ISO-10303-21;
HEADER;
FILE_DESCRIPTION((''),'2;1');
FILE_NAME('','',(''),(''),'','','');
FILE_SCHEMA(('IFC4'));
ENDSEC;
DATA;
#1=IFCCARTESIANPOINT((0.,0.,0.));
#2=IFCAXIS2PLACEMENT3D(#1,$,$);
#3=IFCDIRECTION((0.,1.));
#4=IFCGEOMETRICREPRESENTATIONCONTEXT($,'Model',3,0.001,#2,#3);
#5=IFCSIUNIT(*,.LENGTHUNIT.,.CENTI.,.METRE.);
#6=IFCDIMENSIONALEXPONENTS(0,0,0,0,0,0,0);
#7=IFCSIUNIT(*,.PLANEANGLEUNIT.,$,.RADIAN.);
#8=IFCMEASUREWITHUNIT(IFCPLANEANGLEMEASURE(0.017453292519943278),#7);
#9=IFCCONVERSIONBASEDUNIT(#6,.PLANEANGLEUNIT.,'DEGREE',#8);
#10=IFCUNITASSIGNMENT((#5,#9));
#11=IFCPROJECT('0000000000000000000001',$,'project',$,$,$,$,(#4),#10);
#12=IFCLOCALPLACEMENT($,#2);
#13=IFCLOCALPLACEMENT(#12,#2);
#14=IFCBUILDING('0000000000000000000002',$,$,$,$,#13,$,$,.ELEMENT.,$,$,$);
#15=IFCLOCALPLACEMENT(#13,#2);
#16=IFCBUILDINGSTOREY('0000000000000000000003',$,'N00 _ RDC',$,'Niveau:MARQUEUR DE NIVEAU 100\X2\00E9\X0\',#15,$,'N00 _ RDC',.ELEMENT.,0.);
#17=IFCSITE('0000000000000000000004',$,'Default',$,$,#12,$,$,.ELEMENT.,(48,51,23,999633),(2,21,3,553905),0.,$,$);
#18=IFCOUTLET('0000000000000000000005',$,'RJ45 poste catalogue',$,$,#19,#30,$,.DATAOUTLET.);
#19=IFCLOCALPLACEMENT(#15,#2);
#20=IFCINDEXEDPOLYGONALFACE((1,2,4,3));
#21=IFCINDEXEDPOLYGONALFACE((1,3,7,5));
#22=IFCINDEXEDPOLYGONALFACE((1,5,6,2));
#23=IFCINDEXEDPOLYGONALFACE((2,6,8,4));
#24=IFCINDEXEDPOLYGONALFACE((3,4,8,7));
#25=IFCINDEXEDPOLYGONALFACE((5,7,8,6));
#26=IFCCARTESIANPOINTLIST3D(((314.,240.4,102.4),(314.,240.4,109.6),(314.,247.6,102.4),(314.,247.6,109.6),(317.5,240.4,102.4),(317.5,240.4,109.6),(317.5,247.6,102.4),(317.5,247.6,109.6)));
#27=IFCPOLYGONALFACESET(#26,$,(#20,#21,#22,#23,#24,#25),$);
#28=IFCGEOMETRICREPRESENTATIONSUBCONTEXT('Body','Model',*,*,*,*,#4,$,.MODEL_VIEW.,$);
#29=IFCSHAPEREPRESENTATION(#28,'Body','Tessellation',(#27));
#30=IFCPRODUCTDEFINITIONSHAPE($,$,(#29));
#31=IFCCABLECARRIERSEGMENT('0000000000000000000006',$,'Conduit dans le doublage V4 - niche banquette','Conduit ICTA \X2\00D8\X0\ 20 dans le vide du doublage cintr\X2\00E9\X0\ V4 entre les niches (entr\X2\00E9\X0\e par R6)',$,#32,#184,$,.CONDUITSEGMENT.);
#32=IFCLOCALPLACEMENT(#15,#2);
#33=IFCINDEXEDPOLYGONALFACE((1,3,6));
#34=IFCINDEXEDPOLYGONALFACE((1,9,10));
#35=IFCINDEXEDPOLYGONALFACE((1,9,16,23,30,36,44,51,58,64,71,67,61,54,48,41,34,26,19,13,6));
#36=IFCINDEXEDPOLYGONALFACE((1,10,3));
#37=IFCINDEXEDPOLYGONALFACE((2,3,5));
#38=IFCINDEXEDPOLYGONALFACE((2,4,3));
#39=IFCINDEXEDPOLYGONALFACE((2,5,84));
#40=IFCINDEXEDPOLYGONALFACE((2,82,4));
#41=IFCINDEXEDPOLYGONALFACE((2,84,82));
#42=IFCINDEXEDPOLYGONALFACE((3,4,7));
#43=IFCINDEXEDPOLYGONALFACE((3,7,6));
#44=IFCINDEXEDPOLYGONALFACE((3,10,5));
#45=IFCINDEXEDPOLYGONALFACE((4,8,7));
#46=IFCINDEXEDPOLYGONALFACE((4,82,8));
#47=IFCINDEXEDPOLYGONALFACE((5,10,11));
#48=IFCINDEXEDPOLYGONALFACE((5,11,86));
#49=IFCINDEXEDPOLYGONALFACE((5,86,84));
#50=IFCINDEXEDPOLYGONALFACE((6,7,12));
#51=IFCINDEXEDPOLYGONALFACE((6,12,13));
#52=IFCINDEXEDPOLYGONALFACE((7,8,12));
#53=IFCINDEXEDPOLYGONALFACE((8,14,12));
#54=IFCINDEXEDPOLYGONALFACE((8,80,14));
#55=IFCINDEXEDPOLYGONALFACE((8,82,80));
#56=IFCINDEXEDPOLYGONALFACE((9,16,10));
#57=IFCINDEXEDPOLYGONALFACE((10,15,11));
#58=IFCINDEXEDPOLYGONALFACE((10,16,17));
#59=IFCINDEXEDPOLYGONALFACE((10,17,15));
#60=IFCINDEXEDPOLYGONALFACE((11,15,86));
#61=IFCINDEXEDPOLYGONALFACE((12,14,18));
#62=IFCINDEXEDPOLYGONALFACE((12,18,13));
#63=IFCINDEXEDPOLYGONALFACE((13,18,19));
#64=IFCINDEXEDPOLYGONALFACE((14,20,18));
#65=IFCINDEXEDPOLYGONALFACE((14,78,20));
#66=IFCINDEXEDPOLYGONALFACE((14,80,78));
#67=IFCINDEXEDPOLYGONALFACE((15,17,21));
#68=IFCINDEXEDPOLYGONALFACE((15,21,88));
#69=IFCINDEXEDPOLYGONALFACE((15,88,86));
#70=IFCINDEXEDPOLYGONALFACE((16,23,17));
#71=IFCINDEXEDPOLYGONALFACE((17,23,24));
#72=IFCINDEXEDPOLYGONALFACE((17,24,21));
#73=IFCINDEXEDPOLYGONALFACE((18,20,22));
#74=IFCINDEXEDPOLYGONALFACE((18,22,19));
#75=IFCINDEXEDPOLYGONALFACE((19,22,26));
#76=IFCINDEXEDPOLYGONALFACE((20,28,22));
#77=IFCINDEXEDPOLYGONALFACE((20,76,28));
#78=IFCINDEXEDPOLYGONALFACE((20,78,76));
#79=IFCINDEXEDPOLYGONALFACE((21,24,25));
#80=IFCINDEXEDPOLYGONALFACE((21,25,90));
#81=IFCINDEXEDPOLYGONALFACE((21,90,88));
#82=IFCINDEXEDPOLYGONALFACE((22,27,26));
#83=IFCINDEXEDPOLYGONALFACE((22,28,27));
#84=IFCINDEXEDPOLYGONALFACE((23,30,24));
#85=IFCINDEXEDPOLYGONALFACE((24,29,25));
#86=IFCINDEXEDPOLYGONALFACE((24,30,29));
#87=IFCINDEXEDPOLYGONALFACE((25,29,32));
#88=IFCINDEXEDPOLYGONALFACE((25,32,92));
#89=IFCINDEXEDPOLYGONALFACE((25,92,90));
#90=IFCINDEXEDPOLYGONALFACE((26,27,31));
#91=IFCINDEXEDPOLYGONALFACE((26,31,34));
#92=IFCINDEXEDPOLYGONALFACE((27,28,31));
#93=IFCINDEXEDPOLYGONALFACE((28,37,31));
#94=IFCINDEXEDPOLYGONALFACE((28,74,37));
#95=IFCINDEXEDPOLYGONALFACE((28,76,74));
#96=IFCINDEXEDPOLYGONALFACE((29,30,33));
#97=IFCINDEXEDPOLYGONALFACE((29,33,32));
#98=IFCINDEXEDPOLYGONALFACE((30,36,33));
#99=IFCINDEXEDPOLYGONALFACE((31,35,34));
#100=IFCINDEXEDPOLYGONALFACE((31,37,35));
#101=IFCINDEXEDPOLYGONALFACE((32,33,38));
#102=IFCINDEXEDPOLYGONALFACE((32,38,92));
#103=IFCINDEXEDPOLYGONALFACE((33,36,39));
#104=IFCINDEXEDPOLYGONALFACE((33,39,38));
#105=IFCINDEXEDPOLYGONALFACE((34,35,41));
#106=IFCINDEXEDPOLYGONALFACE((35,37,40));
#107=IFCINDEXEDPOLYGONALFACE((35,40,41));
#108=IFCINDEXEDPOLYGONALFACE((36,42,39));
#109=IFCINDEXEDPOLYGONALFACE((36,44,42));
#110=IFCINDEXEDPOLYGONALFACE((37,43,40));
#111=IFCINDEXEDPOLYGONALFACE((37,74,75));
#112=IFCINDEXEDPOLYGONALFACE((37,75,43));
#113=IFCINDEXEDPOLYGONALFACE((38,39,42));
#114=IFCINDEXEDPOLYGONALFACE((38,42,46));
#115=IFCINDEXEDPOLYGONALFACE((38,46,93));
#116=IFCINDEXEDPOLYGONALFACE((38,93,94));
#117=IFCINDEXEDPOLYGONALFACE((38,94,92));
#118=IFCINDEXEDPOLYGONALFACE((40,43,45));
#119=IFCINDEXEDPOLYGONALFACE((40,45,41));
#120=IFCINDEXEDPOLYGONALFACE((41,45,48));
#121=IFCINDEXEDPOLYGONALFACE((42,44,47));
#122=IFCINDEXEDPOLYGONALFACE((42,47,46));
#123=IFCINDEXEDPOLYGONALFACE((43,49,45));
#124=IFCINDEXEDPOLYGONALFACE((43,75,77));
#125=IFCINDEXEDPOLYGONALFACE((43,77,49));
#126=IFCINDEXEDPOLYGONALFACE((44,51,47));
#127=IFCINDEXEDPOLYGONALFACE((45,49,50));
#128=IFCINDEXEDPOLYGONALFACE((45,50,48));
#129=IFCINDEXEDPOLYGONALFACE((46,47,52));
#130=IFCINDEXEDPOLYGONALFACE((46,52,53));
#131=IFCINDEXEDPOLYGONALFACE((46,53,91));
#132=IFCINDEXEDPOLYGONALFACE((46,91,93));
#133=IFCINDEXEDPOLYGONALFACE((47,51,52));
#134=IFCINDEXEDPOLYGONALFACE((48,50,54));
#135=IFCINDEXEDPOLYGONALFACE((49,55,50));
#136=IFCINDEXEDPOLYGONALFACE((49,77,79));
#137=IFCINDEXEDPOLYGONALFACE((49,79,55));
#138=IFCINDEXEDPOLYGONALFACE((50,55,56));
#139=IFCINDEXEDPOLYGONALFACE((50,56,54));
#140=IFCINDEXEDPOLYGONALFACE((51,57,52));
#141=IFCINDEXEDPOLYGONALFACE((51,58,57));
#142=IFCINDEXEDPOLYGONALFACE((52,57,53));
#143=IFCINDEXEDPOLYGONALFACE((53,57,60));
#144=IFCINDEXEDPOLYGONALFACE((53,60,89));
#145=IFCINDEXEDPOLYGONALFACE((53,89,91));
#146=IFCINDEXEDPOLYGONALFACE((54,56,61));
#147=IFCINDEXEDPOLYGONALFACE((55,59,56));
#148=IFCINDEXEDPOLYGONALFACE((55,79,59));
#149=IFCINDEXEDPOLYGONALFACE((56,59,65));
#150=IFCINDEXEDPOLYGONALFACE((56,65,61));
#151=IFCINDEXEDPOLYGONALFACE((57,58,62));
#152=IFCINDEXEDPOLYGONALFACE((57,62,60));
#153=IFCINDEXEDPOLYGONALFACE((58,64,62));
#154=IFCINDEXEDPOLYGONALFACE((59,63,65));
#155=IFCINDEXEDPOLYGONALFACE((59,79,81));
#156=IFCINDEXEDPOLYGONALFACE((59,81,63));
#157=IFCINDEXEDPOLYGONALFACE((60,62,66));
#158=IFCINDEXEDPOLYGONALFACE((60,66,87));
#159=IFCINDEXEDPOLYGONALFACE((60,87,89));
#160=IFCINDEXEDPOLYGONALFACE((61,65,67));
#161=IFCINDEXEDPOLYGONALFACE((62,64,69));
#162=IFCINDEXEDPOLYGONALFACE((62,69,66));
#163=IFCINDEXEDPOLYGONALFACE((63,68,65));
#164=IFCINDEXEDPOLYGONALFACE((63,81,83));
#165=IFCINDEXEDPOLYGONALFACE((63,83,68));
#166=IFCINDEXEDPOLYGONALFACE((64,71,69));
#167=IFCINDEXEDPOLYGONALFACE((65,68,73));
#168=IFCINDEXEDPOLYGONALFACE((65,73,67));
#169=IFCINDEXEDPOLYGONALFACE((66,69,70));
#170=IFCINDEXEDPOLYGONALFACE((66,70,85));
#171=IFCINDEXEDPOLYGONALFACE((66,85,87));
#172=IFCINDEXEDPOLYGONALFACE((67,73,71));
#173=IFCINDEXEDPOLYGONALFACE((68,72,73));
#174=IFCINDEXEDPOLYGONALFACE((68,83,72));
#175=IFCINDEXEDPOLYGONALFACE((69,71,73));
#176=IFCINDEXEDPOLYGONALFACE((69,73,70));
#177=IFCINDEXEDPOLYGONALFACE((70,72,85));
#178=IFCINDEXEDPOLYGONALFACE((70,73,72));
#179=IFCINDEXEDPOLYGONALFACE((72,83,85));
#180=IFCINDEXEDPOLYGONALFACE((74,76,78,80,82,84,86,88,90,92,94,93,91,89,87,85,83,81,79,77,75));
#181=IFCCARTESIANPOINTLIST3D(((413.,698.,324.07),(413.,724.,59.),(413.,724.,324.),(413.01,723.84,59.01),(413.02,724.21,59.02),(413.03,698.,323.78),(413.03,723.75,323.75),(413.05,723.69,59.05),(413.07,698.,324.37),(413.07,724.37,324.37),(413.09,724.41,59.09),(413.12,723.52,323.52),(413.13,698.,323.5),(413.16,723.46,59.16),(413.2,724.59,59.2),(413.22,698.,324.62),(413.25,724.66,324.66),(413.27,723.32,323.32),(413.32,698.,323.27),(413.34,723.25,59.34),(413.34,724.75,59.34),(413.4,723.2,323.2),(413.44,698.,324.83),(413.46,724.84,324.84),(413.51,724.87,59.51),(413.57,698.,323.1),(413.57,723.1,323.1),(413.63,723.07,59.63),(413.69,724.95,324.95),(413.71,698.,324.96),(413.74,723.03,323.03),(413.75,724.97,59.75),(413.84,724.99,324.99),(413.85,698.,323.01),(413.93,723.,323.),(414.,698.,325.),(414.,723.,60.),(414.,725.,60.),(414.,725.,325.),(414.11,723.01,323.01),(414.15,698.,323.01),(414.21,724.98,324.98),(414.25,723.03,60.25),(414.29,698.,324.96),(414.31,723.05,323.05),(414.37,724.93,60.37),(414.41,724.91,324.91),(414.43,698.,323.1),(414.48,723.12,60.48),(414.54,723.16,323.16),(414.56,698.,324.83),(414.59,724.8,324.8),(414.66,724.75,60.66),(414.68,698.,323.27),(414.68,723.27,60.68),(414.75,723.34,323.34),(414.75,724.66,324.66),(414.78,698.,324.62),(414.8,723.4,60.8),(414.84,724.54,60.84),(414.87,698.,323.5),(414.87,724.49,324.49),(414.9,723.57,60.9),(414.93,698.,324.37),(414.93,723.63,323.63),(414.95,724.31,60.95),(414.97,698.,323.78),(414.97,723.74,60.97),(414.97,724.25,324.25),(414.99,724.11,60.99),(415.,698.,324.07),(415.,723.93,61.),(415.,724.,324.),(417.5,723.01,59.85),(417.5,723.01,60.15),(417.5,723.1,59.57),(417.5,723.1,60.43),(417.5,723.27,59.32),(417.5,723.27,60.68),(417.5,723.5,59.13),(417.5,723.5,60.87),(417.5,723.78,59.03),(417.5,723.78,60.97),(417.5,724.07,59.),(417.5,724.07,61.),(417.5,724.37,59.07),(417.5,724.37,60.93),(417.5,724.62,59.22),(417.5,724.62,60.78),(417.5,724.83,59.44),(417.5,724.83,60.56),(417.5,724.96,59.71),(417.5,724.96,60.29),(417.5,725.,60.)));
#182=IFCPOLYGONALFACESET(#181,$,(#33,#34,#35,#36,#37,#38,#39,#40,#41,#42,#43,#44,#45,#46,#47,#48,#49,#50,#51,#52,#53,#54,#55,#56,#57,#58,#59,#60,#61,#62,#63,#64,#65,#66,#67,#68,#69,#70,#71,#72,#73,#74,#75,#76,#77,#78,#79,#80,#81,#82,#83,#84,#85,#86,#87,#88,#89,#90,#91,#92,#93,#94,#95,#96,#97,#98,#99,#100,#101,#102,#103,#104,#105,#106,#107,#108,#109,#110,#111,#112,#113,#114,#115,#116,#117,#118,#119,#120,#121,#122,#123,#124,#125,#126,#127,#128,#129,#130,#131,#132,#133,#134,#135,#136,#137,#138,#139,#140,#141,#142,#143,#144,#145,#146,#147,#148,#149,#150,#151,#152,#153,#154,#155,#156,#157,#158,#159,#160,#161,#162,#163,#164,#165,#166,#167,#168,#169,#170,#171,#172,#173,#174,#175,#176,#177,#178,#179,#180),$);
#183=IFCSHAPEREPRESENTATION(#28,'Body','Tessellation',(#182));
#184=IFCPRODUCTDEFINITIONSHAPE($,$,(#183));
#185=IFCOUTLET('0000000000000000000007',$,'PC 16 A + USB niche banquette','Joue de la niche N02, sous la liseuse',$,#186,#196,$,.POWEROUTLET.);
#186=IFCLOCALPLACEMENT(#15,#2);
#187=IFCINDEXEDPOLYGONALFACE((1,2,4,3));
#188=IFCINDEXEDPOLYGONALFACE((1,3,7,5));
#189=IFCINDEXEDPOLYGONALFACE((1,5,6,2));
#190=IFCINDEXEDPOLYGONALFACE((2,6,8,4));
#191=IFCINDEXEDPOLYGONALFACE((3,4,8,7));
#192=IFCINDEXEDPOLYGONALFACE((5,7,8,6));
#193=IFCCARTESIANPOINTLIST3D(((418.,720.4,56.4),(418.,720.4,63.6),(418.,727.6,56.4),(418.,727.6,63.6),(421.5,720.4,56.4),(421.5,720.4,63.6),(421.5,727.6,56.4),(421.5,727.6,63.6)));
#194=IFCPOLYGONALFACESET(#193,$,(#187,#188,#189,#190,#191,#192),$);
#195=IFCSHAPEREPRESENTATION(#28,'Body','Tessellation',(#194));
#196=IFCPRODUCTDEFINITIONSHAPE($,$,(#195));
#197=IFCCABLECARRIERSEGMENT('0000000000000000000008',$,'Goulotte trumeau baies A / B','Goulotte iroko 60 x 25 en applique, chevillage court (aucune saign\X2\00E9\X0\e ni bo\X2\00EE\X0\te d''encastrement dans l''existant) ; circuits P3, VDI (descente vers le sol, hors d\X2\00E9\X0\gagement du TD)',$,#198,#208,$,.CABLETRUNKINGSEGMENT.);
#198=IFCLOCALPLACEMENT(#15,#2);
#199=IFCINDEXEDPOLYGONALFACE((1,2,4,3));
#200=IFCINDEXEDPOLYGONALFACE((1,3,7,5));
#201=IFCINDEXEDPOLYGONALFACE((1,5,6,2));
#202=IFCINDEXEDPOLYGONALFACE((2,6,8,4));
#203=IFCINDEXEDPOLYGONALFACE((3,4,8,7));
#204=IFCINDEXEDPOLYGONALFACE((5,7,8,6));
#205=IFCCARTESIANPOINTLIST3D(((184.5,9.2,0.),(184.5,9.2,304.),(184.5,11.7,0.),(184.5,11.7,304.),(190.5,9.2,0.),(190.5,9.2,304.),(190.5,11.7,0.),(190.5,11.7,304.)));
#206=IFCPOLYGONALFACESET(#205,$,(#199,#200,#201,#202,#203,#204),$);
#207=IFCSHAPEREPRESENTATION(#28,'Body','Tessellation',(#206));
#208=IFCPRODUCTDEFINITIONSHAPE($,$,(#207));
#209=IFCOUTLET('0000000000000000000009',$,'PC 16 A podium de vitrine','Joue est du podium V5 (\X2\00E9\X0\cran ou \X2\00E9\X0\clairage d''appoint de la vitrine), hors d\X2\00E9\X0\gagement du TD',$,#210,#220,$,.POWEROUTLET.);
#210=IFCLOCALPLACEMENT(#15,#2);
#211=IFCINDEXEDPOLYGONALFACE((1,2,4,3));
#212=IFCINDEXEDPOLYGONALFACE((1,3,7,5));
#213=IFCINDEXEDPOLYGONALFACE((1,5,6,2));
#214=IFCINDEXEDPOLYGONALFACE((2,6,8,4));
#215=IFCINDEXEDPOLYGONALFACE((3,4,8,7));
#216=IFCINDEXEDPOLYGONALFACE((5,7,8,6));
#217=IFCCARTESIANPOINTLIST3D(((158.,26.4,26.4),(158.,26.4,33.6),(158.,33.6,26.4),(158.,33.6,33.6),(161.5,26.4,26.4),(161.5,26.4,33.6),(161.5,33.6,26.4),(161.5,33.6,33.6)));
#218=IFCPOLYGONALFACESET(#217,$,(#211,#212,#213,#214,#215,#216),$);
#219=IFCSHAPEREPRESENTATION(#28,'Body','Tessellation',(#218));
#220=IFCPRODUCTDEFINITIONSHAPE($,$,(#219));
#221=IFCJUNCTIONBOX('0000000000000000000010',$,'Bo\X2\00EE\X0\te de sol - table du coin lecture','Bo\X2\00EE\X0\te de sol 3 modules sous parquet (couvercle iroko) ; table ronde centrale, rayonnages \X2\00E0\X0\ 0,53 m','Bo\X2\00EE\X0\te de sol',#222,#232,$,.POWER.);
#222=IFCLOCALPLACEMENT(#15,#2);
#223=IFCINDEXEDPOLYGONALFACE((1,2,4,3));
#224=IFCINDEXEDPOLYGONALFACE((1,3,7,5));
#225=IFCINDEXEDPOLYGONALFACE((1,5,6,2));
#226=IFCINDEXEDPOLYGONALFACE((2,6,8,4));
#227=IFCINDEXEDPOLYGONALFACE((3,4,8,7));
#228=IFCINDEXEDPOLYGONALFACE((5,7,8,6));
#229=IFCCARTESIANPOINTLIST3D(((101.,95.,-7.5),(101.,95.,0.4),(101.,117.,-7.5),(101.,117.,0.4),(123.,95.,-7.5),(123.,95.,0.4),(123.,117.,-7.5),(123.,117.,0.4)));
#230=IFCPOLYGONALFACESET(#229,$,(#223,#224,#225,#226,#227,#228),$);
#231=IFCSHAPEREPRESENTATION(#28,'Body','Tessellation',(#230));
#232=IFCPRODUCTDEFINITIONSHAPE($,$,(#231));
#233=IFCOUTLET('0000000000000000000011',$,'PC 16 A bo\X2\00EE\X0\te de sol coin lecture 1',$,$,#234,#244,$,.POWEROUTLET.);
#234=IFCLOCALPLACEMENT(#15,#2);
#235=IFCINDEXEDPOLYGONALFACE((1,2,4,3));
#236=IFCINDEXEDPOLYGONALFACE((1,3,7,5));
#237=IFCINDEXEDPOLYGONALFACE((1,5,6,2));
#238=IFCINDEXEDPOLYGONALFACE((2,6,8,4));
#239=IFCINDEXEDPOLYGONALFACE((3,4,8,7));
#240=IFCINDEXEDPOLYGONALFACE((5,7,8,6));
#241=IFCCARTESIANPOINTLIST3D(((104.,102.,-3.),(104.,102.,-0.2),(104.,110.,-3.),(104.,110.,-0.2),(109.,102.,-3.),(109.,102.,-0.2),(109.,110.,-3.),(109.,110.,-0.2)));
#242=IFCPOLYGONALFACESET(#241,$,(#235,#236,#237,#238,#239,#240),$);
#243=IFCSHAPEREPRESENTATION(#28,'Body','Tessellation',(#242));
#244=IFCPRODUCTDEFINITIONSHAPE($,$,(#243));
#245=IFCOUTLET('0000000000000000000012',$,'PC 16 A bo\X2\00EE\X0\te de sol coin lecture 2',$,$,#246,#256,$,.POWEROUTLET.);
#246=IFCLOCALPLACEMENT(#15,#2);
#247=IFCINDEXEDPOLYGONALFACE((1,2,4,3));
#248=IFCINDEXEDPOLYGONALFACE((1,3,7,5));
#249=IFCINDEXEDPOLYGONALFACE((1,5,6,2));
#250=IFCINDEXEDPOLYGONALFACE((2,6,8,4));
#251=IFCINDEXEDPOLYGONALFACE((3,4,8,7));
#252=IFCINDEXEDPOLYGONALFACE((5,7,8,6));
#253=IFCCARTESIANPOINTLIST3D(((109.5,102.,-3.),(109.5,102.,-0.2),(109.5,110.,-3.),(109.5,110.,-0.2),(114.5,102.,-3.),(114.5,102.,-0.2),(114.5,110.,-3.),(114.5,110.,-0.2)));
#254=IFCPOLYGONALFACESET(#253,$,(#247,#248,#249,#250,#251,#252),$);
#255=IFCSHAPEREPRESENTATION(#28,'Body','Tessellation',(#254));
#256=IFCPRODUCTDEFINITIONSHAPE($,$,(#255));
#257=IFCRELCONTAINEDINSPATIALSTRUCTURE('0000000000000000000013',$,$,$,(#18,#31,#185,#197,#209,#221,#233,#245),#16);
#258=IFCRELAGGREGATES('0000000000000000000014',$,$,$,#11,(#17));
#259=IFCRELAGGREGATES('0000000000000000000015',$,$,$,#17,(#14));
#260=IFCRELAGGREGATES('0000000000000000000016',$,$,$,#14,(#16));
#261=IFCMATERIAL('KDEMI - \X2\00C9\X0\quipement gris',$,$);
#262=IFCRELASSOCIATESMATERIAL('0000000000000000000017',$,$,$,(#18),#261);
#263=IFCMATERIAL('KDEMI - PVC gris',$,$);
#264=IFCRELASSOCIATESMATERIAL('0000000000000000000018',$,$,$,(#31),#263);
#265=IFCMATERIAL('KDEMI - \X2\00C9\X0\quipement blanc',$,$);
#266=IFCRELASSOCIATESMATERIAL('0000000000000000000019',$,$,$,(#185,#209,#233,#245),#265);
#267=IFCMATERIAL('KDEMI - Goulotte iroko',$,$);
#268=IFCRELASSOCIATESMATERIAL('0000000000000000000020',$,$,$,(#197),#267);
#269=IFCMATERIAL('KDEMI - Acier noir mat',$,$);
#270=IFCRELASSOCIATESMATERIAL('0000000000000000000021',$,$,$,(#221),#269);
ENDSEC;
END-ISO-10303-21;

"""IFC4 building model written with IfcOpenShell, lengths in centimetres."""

from ifc_helpers import new_model, entity, si_unit, converted_unit, direction, frame, frame_2d, origin, origin_with_axes, place, context, subcontext, project, spatial, rectangle, extrude, material, element, save


model = new_model("IFC4")

# Units and contexts
model_context = context("Model", 3, precision=0.001, world=origin(), true_north=direction((0.0, 1.0)))
body_context = subcontext(model_context, "Body", "Model", "MODEL_VIEW")
ifc_project = project(units=[si_unit("LENGTHUNIT", "METRE", prefix="CENTI"), converted_unit("PLANEANGLEUNIT", "DEGREE", entity("IfcPlaneAngleMeasure", 0.017453292519943278), si_unit("PLANEANGLEUNIT", "RADIAN"), dimensions=[0, 0, 0, 0, 0, 0, 0])], contexts=[model_context])

# Site, building, storey
site_placement = place(None, origin())
site = spatial("IfcSite", under=ifc_project, at=site_placement, Name="Default", CompositionType="ELEMENT", RefLatitude=(48, 51, 23, 999633), RefLongitude=(2, 21, 3, 553905), RefElevation=0.0)
building_placement = place(site_placement, origin())
building = spatial("IfcBuilding", under=site, at=building_placement, CompositionType="ELEMENT")
storey_placement = place(building_placement, origin())
storey = spatial("IfcBuildingStorey", under=building, at=storey_placement, Name="N00 _ RDC", ObjectType="Niveau:MARQUEUR DE NIVEAU 100é", LongName="N00 _ RDC", CompositionType="ELEMENT", Elevation=0.0)

# Shared definitions
ifc_material_1 = material(Name="KDEMI - Goulotte iroko")

# Shared definitions
ifc_material_2 = material(Name="KDEMI - Équipement blanc")

# Shared definitions
ifc_material_3 = material(Name="KDEMI - Acier noir mat")

# Shared definitions
ifc_material_4 = material(Name="KDEMI - PVC gris")

# Outlet
ifc_material_5 = material(Name="KDEMI - Équipement gris")
outlet_1_placement = place(storey_placement, origin_with_axes())
element("IfcOutlet", 1, at=outlet_1_placement, inside=storey, material=ifc_material_5, Name="RJ45 poste catalogue", PredefinedType="DATAOUTLET", context=body_context, shape_type="SweptSolid", body=[
    extrude(rectangle(XDim=3.5, YDim=7.2, at=frame_2d((315.75, 244.0))), frame((0.0, 0.0, 102.4)), (0.0, 0.0, 1.0), 7.2),
])

# Cable carrier segment
cable_carrier_segment_1_placement = place(storey_placement, origin_with_axes())
element("IfcCableCarrierSegment", 2, at=cable_carrier_segment_1_placement, inside=storey, material=ifc_material_4, Name="Conduit dans le doublage V4 - niche banquette", Description="Conduit ICTA Ø 20 dans le vide du doublage cintré V4 entre les niches (entrée par R6)", PredefinedType="CONDUITSEGMENT", context=body_context, shape_type="AdvancedSweptSolid", body=[
    entity("IfcSweptDiskSolid", entity("IfcPolyline", [entity("IfcCartesianPoint", [414.0, 698.0, 324.0]), entity("IfcCartesianPoint", [414.0, 724.0, 324.0]), entity("IfcCartesianPoint", [414.0, 724.0, 60.0]), entity("IfcCartesianPoint", [417.5, 724.0, 60.0])]), 1.0),
])

# Outlet
outlet_2_placement = place(storey_placement, origin_with_axes())
element("IfcOutlet", 3, at=outlet_2_placement, inside=storey, material=ifc_material_2, Name="PC 16 A + USB niche banquette", Description="Joue de la niche N02, sous la liseuse", PredefinedType="POWEROUTLET", context=body_context, shape_type="SweptSolid", body=[
    extrude(rectangle(XDim=3.5, YDim=7.2, at=frame_2d((419.75, 724.0))), frame((0.0, 0.0, 56.4)), (0.0, 0.0, 1.0), 7.2),
])

# Cable carrier segment
cable_carrier_segment_2_placement = place(storey_placement, origin_with_axes())
element("IfcCableCarrierSegment", 4, at=cable_carrier_segment_2_placement, inside=storey, material=ifc_material_1, Name="Goulotte trumeau baies A / B", Description="Goulotte iroko 60 x 25 en applique, chevillage court (aucune saignée ni boîte d'encastrement dans l'existant) ; circuits P3, VDI (descente vers le sol, hors dégagement du TD)", PredefinedType="CABLETRUNKINGSEGMENT", context=body_context, shape_type="SweptSolid", body=[
    extrude(rectangle(XDim=6.0, YDim=2.5, at=frame_2d((187.5, 10.45))), origin(), (0.0, 0.0, 1.0), 304.0),
])

# Outlet
outlet_3_placement = place(storey_placement, origin_with_axes())
element("IfcOutlet", 5, at=outlet_3_placement, inside=storey, material=ifc_material_2, Name="PC 16 A podium de vitrine", Description="Joue est du podium V5 (écran ou éclairage d'appoint de la vitrine), hors dégagement du TD", PredefinedType="POWEROUTLET", context=body_context, shape_type="SweptSolid", body=[
    extrude(rectangle(XDim=3.5, YDim=7.2, at=frame_2d((159.75, 30.0))), frame((0.0, 0.0, 26.4)), (0.0, 0.0, 1.0), 7.2),
])

# Junction box
junction_box_1_placement = place(storey_placement, origin_with_axes())
element("IfcJunctionBox", 6, at=junction_box_1_placement, inside=storey, material=ifc_material_3, Name="Boîte de sol - table du coin lecture", Description="Boîte de sol 3 modules sous parquet (couvercle iroko) ; table ronde centrale, rayonnages à 0,53 m", ObjectType="Boîte de sol", PredefinedType="POWER", context=body_context, shape_type="SweptSolid", body=[
    extrude(rectangle(XDim=22.0, YDim=22.0, at=frame_2d((112.0, 106.0))), frame((0.0, 0.0, -7.5)), (0.0, 0.0, 1.0), 7.9),
])

# Outlets
outlet_4_placement = place(storey_placement, origin_with_axes())
element("IfcOutlet", 7, at=outlet_4_placement, inside=storey, material=ifc_material_2, Name="PC 16 A boîte de sol coin lecture 1", PredefinedType="POWEROUTLET", context=body_context, shape_type="SweptSolid", body=[
    extrude(rectangle(XDim=5.0, YDim=8.0, at=frame_2d((106.5, 106.0))), frame((0.0, 0.0, -3.0)), (0.0, 0.0, 1.0), 2.8),
])
outlet_5_placement = place(storey_placement, origin_with_axes())
element("IfcOutlet", 8, at=outlet_5_placement, inside=storey, material=ifc_material_2, Name="PC 16 A boîte de sol coin lecture 2", PredefinedType="POWEROUTLET", context=body_context, shape_type="SweptSolid", body=[
    extrude(rectangle(XDim=5.0, YDim=8.0, at=frame_2d((112.0, 106.0))), frame((0.0, 0.0, -3.0)), (0.0, 0.0, 1.0), 2.8),
])

save(model, "model.ifc")
